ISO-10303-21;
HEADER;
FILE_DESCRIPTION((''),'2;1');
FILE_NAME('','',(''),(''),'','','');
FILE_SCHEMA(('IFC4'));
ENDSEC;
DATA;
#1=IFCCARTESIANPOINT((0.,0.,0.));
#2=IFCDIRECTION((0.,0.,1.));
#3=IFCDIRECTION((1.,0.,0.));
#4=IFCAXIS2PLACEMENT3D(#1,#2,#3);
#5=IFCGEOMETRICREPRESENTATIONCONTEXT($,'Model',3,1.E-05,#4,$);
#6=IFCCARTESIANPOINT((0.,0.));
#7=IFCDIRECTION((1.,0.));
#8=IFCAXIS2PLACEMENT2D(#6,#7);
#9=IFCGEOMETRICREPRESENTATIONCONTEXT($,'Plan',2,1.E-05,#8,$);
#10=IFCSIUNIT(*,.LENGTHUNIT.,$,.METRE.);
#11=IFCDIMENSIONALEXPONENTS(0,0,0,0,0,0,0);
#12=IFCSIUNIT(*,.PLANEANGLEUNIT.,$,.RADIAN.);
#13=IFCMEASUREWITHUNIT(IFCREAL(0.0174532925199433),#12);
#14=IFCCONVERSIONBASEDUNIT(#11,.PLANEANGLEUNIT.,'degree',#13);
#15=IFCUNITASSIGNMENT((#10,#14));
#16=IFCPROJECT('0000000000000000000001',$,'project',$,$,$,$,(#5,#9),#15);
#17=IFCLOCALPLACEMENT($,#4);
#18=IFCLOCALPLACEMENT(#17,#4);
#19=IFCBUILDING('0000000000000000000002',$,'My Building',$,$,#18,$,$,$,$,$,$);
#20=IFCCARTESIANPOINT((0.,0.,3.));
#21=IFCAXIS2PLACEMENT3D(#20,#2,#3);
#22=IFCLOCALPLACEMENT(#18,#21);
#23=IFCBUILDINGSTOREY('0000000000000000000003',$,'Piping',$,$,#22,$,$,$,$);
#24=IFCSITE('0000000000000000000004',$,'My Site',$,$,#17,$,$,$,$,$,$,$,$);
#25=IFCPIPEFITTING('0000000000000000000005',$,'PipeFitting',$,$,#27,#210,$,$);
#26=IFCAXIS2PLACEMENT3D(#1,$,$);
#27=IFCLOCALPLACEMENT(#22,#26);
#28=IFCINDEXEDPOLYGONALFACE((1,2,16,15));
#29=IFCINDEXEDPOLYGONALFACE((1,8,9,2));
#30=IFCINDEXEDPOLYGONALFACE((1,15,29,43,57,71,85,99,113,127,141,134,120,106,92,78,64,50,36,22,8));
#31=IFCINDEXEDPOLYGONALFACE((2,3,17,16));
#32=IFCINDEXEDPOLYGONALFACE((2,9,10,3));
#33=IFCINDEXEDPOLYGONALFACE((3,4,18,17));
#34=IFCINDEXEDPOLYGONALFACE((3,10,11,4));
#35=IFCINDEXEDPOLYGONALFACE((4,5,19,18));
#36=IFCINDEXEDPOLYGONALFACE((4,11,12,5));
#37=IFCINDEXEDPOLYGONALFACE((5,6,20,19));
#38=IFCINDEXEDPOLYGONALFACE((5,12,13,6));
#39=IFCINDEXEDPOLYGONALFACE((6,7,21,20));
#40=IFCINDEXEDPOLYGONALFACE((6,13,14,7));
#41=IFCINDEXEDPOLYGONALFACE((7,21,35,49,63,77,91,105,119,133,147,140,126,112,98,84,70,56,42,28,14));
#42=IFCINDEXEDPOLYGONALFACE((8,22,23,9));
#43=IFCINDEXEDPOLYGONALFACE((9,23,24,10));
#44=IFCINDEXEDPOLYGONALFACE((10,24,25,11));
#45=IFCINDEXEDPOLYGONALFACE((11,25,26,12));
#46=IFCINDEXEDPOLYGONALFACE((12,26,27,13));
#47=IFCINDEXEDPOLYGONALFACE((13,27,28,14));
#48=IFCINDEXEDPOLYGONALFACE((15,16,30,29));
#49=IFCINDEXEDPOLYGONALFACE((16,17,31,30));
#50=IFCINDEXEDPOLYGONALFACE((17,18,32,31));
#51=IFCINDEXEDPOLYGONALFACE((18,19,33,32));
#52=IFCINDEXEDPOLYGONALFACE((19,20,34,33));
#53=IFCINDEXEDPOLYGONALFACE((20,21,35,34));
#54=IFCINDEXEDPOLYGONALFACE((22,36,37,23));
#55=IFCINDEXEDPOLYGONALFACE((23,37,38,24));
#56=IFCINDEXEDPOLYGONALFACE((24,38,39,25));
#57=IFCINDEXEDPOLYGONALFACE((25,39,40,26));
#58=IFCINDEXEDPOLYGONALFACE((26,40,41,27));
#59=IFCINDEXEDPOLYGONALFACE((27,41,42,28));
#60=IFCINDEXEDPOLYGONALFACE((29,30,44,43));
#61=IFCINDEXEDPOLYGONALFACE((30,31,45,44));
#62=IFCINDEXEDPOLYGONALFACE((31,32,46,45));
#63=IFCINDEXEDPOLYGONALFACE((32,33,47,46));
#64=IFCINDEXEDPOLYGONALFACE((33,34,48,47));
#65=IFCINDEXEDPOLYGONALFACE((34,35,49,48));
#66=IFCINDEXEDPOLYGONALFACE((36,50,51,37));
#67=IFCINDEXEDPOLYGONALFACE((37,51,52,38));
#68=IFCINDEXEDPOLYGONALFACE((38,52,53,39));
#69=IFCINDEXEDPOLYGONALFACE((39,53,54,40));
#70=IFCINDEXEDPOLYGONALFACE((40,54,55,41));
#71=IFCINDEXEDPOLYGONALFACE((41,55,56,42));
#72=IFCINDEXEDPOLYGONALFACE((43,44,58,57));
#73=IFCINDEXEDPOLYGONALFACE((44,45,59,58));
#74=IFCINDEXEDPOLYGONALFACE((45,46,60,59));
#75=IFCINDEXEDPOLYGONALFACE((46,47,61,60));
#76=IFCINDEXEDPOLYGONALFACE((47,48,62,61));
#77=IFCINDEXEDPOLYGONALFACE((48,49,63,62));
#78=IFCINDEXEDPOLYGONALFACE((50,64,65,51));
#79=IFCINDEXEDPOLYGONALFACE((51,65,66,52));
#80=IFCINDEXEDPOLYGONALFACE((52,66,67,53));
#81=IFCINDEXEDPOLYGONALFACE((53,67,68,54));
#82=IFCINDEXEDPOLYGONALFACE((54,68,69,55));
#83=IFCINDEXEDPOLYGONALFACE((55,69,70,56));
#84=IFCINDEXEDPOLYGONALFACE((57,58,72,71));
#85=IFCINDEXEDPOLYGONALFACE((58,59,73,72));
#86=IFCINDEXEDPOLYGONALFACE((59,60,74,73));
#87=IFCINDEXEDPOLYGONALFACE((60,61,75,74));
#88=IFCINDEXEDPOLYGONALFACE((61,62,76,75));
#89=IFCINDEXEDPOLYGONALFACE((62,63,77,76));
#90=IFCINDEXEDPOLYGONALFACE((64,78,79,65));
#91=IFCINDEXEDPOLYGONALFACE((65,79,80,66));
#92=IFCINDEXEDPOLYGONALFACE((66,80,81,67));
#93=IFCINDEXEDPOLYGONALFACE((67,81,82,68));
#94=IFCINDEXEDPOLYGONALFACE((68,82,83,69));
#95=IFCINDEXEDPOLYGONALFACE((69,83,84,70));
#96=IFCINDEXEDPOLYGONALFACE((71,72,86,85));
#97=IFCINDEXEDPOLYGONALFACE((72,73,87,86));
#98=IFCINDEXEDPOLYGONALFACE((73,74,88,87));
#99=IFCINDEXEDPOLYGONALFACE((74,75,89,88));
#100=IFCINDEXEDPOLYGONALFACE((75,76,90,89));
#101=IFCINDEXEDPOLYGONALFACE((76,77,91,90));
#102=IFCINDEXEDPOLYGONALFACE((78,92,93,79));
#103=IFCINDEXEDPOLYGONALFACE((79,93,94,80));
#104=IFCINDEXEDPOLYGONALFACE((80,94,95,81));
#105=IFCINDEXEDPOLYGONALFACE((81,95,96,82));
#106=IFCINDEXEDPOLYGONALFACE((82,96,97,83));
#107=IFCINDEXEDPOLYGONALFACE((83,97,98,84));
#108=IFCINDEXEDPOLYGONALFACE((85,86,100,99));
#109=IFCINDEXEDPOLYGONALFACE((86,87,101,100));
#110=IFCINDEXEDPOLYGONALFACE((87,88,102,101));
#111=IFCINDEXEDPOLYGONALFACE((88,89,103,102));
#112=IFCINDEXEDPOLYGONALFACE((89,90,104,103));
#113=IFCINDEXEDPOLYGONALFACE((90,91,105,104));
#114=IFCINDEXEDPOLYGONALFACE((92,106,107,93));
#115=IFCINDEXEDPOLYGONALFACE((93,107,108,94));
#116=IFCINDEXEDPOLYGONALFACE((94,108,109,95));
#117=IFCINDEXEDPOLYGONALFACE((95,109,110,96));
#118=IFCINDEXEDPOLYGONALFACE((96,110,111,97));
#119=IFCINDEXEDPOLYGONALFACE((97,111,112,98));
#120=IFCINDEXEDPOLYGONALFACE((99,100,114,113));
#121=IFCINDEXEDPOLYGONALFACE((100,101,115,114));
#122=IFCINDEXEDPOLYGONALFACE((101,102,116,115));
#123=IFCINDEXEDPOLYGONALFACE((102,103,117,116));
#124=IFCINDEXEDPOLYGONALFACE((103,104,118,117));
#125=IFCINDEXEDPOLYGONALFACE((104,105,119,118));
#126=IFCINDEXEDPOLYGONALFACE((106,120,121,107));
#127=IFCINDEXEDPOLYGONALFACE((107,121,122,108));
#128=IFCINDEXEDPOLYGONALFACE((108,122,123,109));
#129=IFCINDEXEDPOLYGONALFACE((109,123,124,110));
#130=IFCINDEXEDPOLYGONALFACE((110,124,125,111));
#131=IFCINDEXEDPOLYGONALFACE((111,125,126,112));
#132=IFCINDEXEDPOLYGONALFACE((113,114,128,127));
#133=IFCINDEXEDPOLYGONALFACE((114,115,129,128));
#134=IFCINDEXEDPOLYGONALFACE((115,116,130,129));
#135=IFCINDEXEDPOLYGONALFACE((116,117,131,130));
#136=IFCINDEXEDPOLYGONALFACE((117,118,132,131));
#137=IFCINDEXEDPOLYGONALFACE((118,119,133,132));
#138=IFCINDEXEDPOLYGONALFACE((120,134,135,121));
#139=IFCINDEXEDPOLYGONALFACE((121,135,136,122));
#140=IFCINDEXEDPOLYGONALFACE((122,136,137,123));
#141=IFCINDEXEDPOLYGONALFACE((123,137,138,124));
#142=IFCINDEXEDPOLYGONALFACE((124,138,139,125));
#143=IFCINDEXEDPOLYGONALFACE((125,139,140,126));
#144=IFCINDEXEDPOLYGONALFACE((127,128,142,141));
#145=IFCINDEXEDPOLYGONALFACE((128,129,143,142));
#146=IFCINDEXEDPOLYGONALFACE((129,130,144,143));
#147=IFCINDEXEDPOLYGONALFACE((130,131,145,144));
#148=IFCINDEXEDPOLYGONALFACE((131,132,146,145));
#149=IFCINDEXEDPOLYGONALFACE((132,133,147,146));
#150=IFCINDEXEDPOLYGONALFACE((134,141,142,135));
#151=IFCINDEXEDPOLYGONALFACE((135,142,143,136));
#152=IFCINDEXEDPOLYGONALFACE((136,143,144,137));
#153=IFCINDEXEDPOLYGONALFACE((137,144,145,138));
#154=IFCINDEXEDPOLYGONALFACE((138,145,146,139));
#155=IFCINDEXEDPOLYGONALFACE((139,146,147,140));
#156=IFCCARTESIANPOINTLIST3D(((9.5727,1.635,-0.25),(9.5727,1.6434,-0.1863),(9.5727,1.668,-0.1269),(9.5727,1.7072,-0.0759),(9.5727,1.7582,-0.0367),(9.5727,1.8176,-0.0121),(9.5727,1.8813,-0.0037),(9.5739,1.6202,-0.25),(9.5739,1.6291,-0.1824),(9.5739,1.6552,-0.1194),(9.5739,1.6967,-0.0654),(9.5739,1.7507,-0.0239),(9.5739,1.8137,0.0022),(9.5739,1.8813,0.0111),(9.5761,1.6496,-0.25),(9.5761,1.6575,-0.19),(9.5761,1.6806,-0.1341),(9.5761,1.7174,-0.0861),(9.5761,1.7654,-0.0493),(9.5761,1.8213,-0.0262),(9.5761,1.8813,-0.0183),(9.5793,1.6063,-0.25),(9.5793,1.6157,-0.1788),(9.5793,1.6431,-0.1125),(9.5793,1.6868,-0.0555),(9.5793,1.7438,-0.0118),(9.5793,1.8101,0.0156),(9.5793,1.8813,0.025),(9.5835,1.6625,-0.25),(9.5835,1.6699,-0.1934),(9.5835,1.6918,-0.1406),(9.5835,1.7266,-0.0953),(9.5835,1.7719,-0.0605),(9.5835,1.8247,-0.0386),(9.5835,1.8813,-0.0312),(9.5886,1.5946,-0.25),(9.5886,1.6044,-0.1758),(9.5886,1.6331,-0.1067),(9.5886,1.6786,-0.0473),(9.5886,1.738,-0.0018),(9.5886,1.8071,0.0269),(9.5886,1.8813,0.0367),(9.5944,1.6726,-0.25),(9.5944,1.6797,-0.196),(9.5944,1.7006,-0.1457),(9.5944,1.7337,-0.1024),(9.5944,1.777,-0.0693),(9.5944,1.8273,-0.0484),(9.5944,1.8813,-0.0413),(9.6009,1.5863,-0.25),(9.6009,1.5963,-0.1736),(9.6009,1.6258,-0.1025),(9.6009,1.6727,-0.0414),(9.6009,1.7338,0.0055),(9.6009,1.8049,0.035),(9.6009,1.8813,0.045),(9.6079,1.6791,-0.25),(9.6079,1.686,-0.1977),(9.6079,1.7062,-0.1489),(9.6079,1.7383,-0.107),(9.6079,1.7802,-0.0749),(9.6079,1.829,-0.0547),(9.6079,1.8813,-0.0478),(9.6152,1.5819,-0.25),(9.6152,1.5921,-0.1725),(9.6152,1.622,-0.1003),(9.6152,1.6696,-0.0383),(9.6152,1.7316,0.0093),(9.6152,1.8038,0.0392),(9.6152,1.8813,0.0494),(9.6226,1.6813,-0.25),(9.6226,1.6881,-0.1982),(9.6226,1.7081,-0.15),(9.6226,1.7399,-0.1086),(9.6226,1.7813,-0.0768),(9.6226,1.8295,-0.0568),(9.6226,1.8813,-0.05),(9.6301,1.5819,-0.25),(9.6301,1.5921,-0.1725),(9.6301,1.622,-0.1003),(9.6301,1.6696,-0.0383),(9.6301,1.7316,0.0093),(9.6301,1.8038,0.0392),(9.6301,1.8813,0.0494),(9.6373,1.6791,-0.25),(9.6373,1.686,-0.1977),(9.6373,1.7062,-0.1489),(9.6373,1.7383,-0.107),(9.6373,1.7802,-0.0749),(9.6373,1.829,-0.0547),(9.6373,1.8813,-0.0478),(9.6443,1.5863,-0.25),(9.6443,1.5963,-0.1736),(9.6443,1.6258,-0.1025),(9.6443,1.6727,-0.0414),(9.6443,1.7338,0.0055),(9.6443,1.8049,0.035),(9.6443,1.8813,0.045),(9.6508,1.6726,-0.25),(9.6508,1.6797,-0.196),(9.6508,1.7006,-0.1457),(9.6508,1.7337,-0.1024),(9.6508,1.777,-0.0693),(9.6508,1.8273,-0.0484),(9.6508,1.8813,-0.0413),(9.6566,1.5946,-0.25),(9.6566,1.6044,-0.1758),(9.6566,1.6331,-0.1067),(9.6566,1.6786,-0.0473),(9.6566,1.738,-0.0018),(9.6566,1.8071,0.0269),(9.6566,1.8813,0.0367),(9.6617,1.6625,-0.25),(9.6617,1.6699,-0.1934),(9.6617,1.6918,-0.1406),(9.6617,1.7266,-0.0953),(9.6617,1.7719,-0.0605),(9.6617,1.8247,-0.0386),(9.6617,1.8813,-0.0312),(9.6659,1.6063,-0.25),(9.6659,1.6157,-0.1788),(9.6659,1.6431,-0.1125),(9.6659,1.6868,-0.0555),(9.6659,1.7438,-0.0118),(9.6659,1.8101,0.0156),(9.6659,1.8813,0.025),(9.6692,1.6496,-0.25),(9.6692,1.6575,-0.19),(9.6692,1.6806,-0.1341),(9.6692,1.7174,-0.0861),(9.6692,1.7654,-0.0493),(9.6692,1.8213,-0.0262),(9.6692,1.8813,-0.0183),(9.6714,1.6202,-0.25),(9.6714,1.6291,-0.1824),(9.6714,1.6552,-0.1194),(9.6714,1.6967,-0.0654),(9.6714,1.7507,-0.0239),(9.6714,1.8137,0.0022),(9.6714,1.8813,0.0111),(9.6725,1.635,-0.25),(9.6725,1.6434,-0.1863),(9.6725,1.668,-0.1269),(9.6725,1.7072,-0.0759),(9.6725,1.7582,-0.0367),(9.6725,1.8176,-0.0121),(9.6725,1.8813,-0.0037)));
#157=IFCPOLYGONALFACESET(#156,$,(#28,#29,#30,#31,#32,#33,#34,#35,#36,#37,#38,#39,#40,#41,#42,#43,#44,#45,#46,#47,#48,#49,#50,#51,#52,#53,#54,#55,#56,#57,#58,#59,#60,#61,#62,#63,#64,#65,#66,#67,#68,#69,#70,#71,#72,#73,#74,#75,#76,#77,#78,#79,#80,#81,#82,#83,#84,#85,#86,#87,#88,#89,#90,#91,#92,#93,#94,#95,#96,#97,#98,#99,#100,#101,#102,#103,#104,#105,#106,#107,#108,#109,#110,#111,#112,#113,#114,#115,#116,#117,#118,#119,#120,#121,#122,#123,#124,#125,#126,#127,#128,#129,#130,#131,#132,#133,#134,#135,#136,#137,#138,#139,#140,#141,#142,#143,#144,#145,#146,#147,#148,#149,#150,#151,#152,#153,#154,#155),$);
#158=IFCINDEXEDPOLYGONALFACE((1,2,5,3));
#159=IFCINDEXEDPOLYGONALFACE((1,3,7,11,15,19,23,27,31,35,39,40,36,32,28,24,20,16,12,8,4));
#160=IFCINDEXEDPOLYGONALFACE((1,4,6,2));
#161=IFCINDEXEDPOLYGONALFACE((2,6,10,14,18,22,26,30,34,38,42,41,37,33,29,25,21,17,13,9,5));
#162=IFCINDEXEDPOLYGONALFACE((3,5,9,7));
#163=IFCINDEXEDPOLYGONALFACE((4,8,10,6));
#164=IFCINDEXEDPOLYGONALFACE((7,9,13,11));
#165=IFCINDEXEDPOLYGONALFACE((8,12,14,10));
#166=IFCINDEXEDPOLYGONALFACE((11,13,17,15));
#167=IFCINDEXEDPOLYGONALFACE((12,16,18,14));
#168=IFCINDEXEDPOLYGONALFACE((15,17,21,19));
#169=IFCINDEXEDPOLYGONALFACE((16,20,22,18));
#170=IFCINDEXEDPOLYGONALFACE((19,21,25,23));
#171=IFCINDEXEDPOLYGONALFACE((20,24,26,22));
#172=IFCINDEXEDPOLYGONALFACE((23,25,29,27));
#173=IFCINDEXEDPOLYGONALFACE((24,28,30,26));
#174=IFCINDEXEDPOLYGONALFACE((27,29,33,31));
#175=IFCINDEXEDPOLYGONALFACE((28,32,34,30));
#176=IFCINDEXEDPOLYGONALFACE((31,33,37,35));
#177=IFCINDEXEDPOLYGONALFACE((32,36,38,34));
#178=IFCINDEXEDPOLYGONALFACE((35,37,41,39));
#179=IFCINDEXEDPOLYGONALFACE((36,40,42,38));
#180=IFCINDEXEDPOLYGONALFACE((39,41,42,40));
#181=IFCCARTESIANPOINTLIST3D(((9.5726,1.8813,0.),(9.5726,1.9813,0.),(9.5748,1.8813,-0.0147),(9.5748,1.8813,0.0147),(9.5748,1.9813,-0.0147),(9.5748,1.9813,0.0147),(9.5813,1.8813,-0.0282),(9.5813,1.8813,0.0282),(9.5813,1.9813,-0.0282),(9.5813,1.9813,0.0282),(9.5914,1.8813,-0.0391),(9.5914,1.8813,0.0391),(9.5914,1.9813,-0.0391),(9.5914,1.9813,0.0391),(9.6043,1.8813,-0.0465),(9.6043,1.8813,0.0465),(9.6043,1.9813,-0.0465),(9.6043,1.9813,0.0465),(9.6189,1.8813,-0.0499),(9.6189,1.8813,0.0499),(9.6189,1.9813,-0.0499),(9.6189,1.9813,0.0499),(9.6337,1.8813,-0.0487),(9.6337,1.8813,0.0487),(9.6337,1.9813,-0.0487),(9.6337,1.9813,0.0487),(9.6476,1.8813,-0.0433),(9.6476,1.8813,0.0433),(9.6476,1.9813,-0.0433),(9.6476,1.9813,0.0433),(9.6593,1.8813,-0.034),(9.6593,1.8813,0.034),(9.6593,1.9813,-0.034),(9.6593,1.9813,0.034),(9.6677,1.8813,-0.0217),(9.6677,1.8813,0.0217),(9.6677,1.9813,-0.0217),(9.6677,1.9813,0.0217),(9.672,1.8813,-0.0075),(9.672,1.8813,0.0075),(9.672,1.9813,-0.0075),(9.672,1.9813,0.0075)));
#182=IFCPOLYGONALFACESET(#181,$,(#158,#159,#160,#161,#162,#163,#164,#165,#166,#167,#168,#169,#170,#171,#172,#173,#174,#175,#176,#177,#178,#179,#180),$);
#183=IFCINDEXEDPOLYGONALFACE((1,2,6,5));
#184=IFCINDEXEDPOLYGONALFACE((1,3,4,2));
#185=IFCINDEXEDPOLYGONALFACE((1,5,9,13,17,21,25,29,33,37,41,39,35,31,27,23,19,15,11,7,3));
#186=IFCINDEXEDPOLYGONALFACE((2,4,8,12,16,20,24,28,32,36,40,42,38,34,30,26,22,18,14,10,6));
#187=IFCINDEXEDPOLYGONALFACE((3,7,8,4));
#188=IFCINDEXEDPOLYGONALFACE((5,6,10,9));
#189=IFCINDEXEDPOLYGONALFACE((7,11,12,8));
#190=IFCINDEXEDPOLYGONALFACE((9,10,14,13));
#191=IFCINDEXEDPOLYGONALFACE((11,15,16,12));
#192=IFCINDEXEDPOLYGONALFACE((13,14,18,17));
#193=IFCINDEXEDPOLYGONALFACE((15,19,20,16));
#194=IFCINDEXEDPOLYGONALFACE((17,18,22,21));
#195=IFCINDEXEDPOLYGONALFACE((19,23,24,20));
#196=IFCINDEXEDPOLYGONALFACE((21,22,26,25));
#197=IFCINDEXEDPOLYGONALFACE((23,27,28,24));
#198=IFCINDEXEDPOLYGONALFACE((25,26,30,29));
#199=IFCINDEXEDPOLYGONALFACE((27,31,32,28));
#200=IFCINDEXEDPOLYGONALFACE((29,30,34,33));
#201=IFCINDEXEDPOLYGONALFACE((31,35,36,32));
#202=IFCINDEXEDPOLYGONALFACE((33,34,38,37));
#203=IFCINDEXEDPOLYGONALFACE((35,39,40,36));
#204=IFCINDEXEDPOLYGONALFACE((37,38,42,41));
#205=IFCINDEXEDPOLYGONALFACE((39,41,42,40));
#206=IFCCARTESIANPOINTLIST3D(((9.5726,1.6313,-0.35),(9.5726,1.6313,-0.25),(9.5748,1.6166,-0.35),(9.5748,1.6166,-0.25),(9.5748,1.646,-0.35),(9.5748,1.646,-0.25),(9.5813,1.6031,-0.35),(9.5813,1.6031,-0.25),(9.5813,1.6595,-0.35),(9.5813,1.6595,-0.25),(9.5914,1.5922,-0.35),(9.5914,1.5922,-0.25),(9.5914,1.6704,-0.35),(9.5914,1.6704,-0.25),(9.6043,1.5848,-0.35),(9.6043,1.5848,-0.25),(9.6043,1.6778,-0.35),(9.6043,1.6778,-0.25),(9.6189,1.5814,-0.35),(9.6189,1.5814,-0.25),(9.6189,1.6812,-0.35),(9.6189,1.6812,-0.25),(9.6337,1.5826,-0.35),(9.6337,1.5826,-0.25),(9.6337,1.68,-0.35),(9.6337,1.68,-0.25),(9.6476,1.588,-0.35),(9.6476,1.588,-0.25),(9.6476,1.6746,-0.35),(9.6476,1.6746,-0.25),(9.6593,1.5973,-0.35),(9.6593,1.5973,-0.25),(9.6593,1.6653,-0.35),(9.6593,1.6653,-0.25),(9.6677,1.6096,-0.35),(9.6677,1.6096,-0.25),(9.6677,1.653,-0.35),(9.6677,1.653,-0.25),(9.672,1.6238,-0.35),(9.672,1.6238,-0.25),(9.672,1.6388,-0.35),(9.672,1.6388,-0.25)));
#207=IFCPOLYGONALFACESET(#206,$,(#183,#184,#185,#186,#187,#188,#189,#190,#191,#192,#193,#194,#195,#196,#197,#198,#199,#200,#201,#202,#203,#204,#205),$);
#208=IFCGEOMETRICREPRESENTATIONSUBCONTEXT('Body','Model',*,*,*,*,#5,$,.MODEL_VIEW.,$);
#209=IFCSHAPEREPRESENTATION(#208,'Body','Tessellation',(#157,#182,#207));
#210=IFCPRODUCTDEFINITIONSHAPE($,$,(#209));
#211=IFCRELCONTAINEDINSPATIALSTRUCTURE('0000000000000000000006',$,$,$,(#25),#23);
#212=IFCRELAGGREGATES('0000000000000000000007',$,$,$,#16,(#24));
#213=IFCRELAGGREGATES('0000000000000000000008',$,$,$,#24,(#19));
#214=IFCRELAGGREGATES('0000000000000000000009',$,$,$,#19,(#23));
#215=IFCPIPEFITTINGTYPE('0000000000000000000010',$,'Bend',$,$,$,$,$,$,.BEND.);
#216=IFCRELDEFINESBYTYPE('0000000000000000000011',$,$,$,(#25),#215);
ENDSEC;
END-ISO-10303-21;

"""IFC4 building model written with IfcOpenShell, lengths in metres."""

from ifc_helpers import new_model, entity, si_unit, converted_unit, frame, origin_with_axes, origin_2d_with_axis, place, context, subcontext, project, spatial, circle, extrude, source, transform, mapped, type_object, type_shapes, element, save


model = new_model("IFC4")

# Units and contexts
model_context = context("Model", 3, precision=1e-05, world=origin_with_axes())
plan_context = context("Plan", 2, precision=1e-05, world=origin_2d_with_axis())
body_context = subcontext(model_context, "Body", "Model", "MODEL_VIEW")
ifc_project = project(units=[si_unit("LENGTHUNIT", "METRE"), converted_unit("PLANEANGLEUNIT", "degree", entity("IfcReal", 0.0174532925199433), si_unit("PLANEANGLEUNIT", "RADIAN"), dimensions=[0, 0, 0, 0, 0, 0, 0])], contexts=[model_context, plan_context])

# Site, building, storey
site_placement = place(None, origin_with_axes())
site = spatial("IfcSite", under=ifc_project, at=site_placement, Name="My Site")
building_placement = place(site_placement, origin_with_axes())
building = spatial("IfcBuilding", under=site, at=building_placement, Name="My Building")
storey_placement = place(building_placement, frame((0.0, 0.0, 3.0), z_axis=(0.0, 0.0, 1.0), x_axis=(1.0, 0.0, 0.0)))
storey = spatial("IfcBuildingStorey", under=building, at=storey_placement, Name="Piping")

# Pipe fitting
pipe_fitting_type = type_object("IfcPipeFittingType", Name="Bend", PredefinedType="BEND")
shared_shape = source(origin_with_axes(), body_context, "Body", "SolidModel", [
    entity("IfcSweptDiskSolid", entity("IfcIndexedPolyCurve", entity("IfcCartesianPointList3D", [[0.0, 0.0, -0.1], [0.0, -0.0732, -0.2768], [0.0, -0.25, -0.35]]), [entity("IfcArcIndex", [1, 2, 3])]), 0.05),
    extrude(circle(Radius=0.05), origin_with_axes(), (0.0, 0.0, -1.0), 0.1),
    extrude(circle(Radius=0.05), frame((0.0, -0.25, -0.35), z_axis=(0.0, -1.0, 0.0), x_axis=(1.0, 0.0, 0.0)), (0.0, 0.0, 1.0), 0.1),
])
type_shapes(pipe_fitting_type, [shared_shape])
for number, where, z_axis, x_axis, name in (
    (1, (9.6226, 1.9813, 0.0), (0.0, 1.0, 0.0), (-1.0, 0.0, 0.0), "PipeFitting"),
):
    element("IfcPipeFitting", number, at=place(storey_placement, frame(where, z_axis=z_axis, x_axis=x_axis)), inside=storey, type_object=pipe_fitting_type, Name=name, context=body_context, shape_type="MappedRepresentation", body=[
        mapped(shared_shape, transform((0.0, 0.0, 0.0), x_axis=(1.0, 0.0, 0.0), y_axis=(0.0, 1.0, 0.0), z_axis=(0.0, 0.0, 1.0), scale=1.0)),
    ])

save(model, "model.ifc")
